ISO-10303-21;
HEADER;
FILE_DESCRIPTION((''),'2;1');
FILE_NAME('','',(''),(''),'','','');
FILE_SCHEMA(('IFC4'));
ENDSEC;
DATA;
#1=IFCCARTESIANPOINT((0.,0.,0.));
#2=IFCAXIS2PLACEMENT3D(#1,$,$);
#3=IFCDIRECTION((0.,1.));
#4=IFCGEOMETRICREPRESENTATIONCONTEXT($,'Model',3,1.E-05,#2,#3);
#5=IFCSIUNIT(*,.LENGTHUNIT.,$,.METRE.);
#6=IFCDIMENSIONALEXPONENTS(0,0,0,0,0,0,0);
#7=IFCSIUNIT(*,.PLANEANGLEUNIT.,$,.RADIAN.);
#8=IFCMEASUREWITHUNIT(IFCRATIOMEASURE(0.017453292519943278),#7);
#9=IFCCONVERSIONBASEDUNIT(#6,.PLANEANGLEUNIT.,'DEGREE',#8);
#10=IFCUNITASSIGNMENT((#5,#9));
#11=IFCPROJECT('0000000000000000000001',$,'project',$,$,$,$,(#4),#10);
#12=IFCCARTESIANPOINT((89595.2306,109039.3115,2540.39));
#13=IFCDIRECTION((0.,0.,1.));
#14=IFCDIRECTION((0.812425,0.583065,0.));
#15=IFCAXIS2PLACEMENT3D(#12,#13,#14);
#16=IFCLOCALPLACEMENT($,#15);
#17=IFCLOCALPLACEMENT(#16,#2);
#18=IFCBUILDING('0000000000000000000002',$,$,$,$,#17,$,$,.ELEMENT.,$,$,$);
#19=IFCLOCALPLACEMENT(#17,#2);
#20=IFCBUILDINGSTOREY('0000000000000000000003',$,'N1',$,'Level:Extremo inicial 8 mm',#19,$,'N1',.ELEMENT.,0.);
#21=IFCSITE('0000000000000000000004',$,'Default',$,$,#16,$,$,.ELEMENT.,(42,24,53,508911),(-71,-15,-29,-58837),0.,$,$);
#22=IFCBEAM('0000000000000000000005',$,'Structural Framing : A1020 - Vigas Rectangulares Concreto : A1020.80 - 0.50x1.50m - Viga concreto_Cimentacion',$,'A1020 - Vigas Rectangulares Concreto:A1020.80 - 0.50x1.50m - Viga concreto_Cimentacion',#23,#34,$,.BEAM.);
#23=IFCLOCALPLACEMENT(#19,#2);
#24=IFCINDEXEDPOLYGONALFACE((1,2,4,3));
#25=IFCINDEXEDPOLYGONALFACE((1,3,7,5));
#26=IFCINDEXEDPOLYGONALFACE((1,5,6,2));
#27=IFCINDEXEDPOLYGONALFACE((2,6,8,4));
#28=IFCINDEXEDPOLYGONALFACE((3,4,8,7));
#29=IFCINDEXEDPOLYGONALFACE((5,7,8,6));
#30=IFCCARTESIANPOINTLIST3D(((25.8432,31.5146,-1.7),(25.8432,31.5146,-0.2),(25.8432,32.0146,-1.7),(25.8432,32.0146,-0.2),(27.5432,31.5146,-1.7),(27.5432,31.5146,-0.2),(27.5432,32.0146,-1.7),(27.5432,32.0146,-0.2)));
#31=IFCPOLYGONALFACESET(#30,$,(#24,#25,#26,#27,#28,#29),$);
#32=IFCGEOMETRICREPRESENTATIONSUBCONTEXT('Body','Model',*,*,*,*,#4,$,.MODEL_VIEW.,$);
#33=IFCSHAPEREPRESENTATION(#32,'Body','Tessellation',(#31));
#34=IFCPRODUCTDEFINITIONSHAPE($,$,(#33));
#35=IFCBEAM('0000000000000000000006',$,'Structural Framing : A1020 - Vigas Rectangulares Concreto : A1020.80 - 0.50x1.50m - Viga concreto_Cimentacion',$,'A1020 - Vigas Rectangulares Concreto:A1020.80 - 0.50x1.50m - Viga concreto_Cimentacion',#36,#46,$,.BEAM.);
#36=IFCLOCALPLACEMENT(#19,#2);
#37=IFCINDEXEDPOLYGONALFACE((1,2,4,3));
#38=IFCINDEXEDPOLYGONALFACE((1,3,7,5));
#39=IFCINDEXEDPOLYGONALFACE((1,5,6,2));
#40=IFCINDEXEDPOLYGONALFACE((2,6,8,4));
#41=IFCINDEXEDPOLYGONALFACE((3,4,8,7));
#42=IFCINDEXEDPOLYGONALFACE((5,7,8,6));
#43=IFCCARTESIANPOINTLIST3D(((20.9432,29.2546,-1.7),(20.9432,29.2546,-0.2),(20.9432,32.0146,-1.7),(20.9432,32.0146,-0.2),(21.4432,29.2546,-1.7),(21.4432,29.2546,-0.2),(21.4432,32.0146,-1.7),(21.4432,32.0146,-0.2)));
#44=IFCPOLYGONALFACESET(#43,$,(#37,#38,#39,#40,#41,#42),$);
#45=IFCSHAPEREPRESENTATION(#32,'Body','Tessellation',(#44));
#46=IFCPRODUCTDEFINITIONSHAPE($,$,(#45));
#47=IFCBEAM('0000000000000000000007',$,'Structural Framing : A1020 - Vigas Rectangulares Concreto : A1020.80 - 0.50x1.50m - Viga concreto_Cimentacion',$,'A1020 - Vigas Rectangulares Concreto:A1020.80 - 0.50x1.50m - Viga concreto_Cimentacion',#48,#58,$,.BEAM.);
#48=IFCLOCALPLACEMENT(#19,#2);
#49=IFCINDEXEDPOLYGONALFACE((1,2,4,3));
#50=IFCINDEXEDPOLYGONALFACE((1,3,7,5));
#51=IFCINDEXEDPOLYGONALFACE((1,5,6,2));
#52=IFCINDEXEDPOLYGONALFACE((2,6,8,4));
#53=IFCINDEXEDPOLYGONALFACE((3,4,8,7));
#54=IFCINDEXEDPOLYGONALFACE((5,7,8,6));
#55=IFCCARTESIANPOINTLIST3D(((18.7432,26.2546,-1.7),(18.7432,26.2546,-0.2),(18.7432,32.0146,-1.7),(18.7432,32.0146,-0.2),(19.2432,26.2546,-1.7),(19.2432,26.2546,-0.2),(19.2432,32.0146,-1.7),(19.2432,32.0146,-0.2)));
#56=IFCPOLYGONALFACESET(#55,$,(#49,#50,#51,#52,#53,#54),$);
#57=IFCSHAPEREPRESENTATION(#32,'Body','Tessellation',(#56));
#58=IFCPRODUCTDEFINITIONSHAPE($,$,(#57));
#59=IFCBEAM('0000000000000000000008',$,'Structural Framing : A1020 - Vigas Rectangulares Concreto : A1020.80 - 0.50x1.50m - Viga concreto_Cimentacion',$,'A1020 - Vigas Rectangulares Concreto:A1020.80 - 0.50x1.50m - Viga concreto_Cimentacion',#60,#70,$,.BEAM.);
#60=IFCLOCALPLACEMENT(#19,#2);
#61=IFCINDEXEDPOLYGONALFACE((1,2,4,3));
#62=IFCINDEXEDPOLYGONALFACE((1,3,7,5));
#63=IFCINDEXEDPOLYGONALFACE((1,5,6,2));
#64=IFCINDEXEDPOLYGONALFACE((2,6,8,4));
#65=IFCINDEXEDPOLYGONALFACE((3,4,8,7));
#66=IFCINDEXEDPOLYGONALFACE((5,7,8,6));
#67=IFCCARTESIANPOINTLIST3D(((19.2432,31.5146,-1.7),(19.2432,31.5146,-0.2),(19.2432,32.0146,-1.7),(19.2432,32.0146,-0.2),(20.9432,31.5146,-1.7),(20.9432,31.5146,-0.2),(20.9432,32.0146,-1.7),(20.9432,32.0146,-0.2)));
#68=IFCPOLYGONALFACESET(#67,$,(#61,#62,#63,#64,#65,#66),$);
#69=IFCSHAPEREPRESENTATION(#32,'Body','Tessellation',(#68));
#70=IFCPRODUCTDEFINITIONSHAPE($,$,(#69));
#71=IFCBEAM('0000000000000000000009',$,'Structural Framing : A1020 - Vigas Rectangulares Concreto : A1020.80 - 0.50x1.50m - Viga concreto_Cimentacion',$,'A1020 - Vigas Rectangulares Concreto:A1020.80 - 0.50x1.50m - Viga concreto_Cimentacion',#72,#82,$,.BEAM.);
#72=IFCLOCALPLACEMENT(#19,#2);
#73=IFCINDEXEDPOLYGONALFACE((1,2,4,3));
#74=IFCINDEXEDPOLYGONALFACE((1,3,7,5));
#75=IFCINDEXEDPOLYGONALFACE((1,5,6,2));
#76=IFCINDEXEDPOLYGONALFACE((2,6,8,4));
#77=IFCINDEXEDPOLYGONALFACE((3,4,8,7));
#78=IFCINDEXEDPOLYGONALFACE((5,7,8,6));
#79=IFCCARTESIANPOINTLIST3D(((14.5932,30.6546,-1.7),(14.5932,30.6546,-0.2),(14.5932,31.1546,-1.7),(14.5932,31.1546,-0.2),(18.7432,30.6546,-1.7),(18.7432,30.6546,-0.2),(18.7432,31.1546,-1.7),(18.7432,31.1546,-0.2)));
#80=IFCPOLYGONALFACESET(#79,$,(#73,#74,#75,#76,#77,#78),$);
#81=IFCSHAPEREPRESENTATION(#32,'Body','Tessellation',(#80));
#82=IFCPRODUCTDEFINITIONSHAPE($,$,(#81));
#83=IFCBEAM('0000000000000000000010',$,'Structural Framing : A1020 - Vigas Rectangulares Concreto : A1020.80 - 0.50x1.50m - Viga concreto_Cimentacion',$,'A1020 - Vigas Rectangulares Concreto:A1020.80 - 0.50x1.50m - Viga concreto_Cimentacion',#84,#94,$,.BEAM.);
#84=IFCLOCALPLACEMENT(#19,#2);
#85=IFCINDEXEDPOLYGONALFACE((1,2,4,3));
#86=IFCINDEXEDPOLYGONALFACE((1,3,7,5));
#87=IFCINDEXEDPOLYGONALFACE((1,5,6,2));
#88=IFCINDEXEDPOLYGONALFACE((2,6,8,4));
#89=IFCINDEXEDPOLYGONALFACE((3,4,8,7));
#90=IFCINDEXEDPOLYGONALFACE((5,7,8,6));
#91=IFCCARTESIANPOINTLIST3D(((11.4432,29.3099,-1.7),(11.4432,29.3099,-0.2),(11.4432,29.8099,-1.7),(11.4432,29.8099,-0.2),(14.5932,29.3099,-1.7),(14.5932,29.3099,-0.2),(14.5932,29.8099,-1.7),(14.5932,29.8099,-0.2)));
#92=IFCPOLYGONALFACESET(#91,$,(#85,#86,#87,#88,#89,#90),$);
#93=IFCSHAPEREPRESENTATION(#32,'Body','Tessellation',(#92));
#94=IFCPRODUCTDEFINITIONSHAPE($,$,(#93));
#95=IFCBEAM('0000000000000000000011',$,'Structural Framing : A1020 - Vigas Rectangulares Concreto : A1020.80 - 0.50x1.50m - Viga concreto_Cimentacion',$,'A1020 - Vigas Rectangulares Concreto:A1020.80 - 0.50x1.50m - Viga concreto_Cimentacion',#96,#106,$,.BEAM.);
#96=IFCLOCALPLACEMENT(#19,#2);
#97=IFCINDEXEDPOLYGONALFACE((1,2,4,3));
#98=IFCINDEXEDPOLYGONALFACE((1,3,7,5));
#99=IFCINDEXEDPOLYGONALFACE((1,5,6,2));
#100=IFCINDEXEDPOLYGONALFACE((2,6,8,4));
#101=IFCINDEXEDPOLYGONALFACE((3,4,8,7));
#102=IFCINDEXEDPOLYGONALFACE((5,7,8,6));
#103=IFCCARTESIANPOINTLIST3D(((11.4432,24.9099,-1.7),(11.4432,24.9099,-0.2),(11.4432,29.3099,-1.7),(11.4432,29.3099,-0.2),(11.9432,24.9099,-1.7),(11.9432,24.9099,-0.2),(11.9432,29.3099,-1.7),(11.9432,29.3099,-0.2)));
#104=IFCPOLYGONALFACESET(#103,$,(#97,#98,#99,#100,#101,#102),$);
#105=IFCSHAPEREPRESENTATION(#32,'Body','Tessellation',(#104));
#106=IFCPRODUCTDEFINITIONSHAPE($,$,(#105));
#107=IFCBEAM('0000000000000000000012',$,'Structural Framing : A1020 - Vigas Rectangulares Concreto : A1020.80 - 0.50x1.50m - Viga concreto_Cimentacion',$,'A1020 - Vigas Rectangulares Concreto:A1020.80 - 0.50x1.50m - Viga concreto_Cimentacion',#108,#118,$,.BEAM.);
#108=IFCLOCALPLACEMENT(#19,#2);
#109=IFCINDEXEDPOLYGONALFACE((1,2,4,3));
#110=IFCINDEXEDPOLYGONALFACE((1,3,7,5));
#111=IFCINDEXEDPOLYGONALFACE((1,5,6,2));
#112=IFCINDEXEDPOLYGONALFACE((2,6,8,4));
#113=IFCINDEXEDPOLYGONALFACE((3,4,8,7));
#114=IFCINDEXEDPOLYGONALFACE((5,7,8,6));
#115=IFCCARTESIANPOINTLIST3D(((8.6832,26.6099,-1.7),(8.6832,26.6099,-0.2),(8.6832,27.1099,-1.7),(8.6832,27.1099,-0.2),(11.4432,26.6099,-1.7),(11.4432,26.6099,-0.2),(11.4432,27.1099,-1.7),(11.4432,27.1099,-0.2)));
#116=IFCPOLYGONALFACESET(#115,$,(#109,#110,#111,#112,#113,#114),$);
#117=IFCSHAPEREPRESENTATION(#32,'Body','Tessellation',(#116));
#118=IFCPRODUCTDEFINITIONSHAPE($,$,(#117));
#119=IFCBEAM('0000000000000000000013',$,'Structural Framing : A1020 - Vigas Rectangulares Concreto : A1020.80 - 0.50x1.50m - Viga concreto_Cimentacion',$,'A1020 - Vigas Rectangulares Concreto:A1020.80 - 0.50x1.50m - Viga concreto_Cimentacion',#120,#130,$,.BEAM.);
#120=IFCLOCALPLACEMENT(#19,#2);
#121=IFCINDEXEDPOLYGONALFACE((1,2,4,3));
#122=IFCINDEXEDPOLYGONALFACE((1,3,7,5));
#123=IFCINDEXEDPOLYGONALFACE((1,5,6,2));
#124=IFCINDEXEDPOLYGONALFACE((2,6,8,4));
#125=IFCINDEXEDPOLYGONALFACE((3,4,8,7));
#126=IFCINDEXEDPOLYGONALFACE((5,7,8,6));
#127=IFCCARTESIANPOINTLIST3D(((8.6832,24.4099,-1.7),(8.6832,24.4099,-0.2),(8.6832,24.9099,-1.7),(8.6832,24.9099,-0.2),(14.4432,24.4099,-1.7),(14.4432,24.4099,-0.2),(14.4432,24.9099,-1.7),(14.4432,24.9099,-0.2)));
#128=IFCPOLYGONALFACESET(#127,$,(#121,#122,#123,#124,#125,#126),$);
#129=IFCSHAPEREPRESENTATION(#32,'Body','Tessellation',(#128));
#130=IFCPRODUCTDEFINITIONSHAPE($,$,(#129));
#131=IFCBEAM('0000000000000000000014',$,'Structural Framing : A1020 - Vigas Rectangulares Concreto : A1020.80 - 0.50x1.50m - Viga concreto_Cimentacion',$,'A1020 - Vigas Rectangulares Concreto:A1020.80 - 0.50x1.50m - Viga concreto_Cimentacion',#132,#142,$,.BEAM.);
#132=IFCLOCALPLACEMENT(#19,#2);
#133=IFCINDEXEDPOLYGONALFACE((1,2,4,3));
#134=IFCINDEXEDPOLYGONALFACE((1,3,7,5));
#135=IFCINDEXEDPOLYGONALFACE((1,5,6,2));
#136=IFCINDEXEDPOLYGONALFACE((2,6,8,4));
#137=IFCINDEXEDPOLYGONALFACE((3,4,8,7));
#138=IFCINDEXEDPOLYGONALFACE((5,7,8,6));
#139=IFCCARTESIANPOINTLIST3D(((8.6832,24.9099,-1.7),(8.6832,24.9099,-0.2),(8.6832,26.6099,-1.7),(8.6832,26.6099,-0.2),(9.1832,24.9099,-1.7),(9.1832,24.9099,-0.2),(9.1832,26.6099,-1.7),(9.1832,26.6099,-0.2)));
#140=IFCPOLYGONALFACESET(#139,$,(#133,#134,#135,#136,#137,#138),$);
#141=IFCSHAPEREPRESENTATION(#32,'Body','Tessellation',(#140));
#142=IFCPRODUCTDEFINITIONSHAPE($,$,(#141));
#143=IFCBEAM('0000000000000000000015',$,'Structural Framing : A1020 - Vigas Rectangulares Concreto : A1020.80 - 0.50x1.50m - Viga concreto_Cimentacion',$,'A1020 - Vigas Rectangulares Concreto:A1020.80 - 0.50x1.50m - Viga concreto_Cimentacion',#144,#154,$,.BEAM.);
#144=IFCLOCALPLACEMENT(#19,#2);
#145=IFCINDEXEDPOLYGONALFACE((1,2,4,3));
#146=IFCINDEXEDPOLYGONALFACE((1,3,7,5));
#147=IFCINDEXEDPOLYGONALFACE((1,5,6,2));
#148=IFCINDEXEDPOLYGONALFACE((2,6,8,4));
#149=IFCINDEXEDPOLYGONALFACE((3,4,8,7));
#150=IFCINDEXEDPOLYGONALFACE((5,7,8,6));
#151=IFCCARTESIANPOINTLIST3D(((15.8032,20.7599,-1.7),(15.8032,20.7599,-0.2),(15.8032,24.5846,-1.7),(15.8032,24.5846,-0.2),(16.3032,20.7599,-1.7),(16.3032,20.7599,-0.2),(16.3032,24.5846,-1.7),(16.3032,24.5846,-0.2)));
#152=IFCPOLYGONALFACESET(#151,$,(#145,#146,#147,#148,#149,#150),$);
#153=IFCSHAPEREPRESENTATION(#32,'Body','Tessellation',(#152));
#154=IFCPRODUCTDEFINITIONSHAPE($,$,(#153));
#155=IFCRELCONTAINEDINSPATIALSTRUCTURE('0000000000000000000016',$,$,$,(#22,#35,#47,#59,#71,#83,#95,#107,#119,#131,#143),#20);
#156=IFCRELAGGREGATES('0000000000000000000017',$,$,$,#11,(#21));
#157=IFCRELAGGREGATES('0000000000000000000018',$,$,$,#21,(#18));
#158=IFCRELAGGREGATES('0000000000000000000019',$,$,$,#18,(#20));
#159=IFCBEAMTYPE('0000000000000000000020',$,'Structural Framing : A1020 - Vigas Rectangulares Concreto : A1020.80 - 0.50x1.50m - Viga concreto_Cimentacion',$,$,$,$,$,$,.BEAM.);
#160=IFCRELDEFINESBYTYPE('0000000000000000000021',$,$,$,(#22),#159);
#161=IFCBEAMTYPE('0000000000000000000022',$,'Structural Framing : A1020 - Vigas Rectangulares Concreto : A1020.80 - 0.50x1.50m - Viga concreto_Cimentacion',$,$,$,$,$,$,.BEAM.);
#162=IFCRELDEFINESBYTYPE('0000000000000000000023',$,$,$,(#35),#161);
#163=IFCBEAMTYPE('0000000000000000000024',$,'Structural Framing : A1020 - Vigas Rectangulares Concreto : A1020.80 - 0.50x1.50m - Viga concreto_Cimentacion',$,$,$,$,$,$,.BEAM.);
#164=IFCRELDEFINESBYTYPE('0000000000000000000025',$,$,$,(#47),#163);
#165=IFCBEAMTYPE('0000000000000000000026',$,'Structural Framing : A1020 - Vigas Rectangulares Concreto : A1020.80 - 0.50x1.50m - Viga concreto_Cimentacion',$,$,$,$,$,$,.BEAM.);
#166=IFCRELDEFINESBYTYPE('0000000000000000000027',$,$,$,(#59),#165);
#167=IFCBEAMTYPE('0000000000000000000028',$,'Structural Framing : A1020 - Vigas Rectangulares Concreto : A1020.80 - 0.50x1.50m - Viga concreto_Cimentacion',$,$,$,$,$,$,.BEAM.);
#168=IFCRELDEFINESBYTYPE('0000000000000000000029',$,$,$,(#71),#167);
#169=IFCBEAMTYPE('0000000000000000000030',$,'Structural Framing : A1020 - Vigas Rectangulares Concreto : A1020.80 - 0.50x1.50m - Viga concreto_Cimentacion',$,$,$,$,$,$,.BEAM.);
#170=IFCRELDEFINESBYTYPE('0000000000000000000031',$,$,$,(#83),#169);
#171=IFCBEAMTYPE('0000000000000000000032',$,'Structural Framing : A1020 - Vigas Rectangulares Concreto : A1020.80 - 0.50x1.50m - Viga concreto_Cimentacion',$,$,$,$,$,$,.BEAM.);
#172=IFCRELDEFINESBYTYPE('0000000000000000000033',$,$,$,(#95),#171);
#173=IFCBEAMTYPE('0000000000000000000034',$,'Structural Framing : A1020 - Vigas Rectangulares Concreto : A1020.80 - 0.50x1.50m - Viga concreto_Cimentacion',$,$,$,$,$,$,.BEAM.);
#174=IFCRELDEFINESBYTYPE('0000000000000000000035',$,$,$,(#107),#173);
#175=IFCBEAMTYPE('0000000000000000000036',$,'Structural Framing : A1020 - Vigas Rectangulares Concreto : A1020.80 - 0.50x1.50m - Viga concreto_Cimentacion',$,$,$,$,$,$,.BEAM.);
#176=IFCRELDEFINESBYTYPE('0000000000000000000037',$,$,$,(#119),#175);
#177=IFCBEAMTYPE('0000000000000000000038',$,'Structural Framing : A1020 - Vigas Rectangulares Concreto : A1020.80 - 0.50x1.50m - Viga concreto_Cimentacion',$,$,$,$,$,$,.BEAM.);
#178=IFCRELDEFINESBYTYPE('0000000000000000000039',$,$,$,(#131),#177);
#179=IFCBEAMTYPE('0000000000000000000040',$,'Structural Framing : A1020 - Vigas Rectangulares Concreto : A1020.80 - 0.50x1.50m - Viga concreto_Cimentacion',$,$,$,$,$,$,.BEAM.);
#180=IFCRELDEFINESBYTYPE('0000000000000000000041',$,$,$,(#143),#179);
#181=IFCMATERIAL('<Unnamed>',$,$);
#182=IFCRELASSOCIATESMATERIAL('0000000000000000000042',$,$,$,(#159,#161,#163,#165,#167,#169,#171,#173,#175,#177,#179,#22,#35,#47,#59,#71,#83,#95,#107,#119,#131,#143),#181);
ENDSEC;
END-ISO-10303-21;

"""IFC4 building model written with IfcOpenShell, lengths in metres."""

from ifc_helpers import new_model, entity, si_unit, converted_unit, direction, frame, frame_2d, origin, origin_2d_with_axis, place, context, subcontext, project, spatial, polyline, segment, composite_curve, rectangle, outline, extrude, source, transform, mapped, material, material_profile, profile_set, profile_usage, type_object, type_shapes, element, save


model = new_model("IFC4")

# Units and contexts
model_context = context("Model", 3, precision=1e-05, world=origin(), true_north=direction((0.0, 1.0)))
body_context = subcontext(model_context, "Body", "Model", "MODEL_VIEW")
ifc_project = project(units=[si_unit("LENGTHUNIT", "METRE"), converted_unit("PLANEANGLEUNIT", "DEGREE", entity("IfcRatioMeasure", 0.017453292519943278), si_unit("PLANEANGLEUNIT", "RADIAN"), dimensions=[0, 0, 0, 0, 0, 0, 0])], contexts=[model_context])

# Site, building, storey
site_placement = place(None, frame((89595.2306, 109039.3115, 2540.39), z_axis=(0.0, 0.0, 1.0), x_axis=(0.812425, 0.583065, 0.0)))
site = spatial("IfcSite", under=ifc_project, at=site_placement, Name="Default", CompositionType="ELEMENT", RefLatitude=(42, 24, 53, 508911), RefLongitude=(-71, -15, -29, -58837), RefElevation=0.0)
building_placement = place(site_placement, origin())
building = spatial("IfcBuilding", under=site, at=building_placement, CompositionType="ELEMENT")
storey_placement = place(building_placement, origin())
storey = spatial("IfcBuildingStorey", under=building, at=storey_placement, Name="N1", ObjectType="Level:Extremo inicial 8 mm", LongName="N1", CompositionType="ELEMENT", Elevation=0.0)

# Beams
ifc_material = material(Name="<Unnamed>")
ifc_material_profile_1 = material_profile(ifc_material, outline(composite_curve([segment(polyline([(0.25, 0.75, 0.0), (0.25, -0.75, 0.0)]), True, "CONTINUOUS"), segment(polyline([(0.25, -0.75, 0.0), (-0.25, -0.75, 0.0)]), True, "CONTINUOUS"), segment(polyline([(-0.25, -0.75, 0.0), (-0.25, 0.75, 0.0)]), True, "CONTINUOUS"), segment(polyline([(-0.25, 0.75, 0.0), (0.25, 0.75, 0.0)]), True, "CONTINUOUS")], self_intersect=False), kind="CURVE"), Name="A1020.80 - 0.50x1.50m - Viga concreto_Cimentacion")
ifc_material_profile_2 = material_profile(ifc_material, outline(composite_curve([segment(polyline([(-5.3373, 0.25, 0.75), (-5.3373, 0.25, -0.75)]), True, "CONTINUOUS"), segment(polyline([(-5.3373, 0.25, -0.75), (-5.3373, -0.25, -0.75)]), True, "CONTINUOUS"), segment(polyline([(-5.3373, -0.25, -0.75), (-5.3373, -0.25, 0.75)]), True, "CONTINUOUS"), segment(polyline([(-5.3373, -0.25, 0.75), (-5.3373, 0.25, 0.75)]), True, "CONTINUOUS")], self_intersect=False), kind="CURVE"), Name="A1020.80 - 0.50x1.50m - Viga concreto_Cimentacion")
ifc_profile_set_1 = profile_set([ifc_material_profile_1, ifc_material_profile_2], Name="A1020.80 - 0.50x1.50m - Viga concreto_Cimentacion")
ifc_profile_usage_1 = profile_usage(ifc_profile_set_1, cardinal=8)
beam_type_1 = type_object("IfcBeamType", Name="Structural Framing : A1020 - Vigas Rectangulares Concreto : A1020.80 - 0.50x1.50m - Viga concreto_Cimentacion", PredefinedType="BEAM", material=ifc_profile_set_1)
shared_shape_1 = source(origin(), body_context, "Body", "SweptSolid", [
    extrude(rectangle(XDim=1.5, YDim=0.5, at=frame_2d((0.0, 0.0), x_axis=(1.0, 0.0))), frame((27.5432, 31.7646, -0.95), z_axis=(-1.0, 0.0, 0.0), x_axis=(0.0, 0.0, -1.0)), (0.0, 0.0, 1.0), 1.7),
])
type_shapes(beam_type_1, [shared_shape_1])
beam_1_placement = place(storey_placement, origin())
element("IfcBeam", 1, at=beam_1_placement, inside=storey, type_object=beam_type_1, material=ifc_profile_usage_1, Name="Structural Framing : A1020 - Vigas Rectangulares Concreto : A1020.80 - 0.50x1.50m - Viga concreto_Cimentacion", ObjectType="A1020 - Vigas Rectangulares Concreto:A1020.80 - 0.50x1.50m - Viga concreto_Cimentacion", PredefinedType="BEAM", context=body_context, shape_type="MappedRepresentation", body=[
    mapped(shared_shape_1, transform((0.0, 0.0, 0.0), scale=1.0)),
])
ifc_profile_usage_2 = profile_usage(ifc_profile_set_1, cardinal=8)
beam_type_2 = type_object("IfcBeamType", Name="Structural Framing : A1020 - Vigas Rectangulares Concreto : A1020.80 - 0.50x1.50m - Viga concreto_Cimentacion", PredefinedType="BEAM", material=ifc_profile_set_1)
shared_shape_2 = source(origin(), body_context, "Body", "SweptSolid", [
    extrude(rectangle(XDim=1.5, YDim=0.5, at=frame_2d((0.0, 0.0), x_axis=(0.0, 1.0))), frame((21.1932, 29.2546, -0.95), z_axis=(0.0, 1.0, 0.0), x_axis=(-1.0, 0.0, 0.0)), (0.0, 0.0, 1.0), 2.76),
])
type_shapes(beam_type_2, [shared_shape_2])
beam_2_placement = place(storey_placement, origin())
element("IfcBeam", 2, at=beam_2_placement, inside=storey, type_object=beam_type_2, material=ifc_profile_usage_2, Name="Structural Framing : A1020 - Vigas Rectangulares Concreto : A1020.80 - 0.50x1.50m - Viga concreto_Cimentacion", ObjectType="A1020 - Vigas Rectangulares Concreto:A1020.80 - 0.50x1.50m - Viga concreto_Cimentacion", PredefinedType="BEAM", context=body_context, shape_type="MappedRepresentation", body=[
    mapped(shared_shape_2, transform((0.0, 0.0, 0.0), scale=1.0)),
])
ifc_profile_usage_3 = profile_usage(ifc_profile_set_1, cardinal=8)
beam_type_3 = type_object("IfcBeamType", Name="Structural Framing : A1020 - Vigas Rectangulares Concreto : A1020.80 - 0.50x1.50m - Viga concreto_Cimentacion", PredefinedType="BEAM", material=ifc_profile_set_1)
shared_shape_3 = source(origin(), body_context, "Body", "SweptSolid", [
    extrude(rectangle(XDim=1.5, YDim=0.5, at=frame_2d((0.0, 0.0), x_axis=(0.0, 1.0))), frame((18.9932, 26.2546, -0.95), z_axis=(0.0, 1.0, 0.0), x_axis=(-1.0, 0.0, 0.0)), (0.0, 0.0, 1.0), 5.76),
])
type_shapes(beam_type_3, [shared_shape_3])
beam_3_placement = place(storey_placement, origin())
element("IfcBeam", 3, at=beam_3_placement, inside=storey, type_object=beam_type_3, material=ifc_profile_usage_3, Name="Structural Framing : A1020 - Vigas Rectangulares Concreto : A1020.80 - 0.50x1.50m - Viga concreto_Cimentacion", ObjectType="A1020 - Vigas Rectangulares Concreto:A1020.80 - 0.50x1.50m - Viga concreto_Cimentacion", PredefinedType="BEAM", context=body_context, shape_type="MappedRepresentation", body=[
    mapped(shared_shape_3, transform((0.0, 0.0, 0.0), scale=1.0)),
])
ifc_profile_usage_4 = profile_usage(ifc_profile_set_1, cardinal=8)
beam_type_4 = type_object("IfcBeamType", Name="Structural Framing : A1020 - Vigas Rectangulares Concreto : A1020.80 - 0.50x1.50m - Viga concreto_Cimentacion", PredefinedType="BEAM", material=ifc_profile_set_1)
shared_shape_4 = source(origin(), body_context, "Body", "SweptSolid", [
    extrude(rectangle(XDim=1.5, YDim=0.5, at=origin_2d_with_axis()), frame((19.2432, 31.7646, -0.95), z_axis=(1.0, 0.0, 0.0), x_axis=(0.0, 0.0, -1.0)), (0.0, 0.0, 1.0), 1.7),
])
type_shapes(beam_type_4, [shared_shape_4])
beam_4_placement = place(storey_placement, origin())
element("IfcBeam", 4, at=beam_4_placement, inside=storey, type_object=beam_type_4, material=ifc_profile_usage_4, Name="Structural Framing : A1020 - Vigas Rectangulares Concreto : A1020.80 - 0.50x1.50m - Viga concreto_Cimentacion", ObjectType="A1020 - Vigas Rectangulares Concreto:A1020.80 - 0.50x1.50m - Viga concreto_Cimentacion", PredefinedType="BEAM", context=body_context, shape_type="MappedRepresentation", body=[
    mapped(shared_shape_4, transform((0.0, 0.0, 0.0), scale=1.0)),
])
ifc_profile_usage_5 = profile_usage(ifc_profile_set_1, cardinal=8)
beam_type_5 = type_object("IfcBeamType", Name="Structural Framing : A1020 - Vigas Rectangulares Concreto : A1020.80 - 0.50x1.50m - Viga concreto_Cimentacion", PredefinedType="BEAM", material=ifc_profile_set_1)
shared_shape_5 = source(origin(), body_context, "Body", "SweptSolid", [
    extrude(rectangle(XDim=1.5, YDim=0.5, at=frame_2d((0.0, 0.0), x_axis=(1.0, 0.0))), frame((18.7432, 30.9046, -0.95), z_axis=(-1.0, 0.0, 0.0), x_axis=(0.0, 0.0, -1.0)), (0.0, 0.0, 1.0), 4.15),
])
type_shapes(beam_type_5, [shared_shape_5])
beam_5_placement = place(storey_placement, origin())
element("IfcBeam", 5, at=beam_5_placement, inside=storey, type_object=beam_type_5, material=ifc_profile_usage_5, Name="Structural Framing : A1020 - Vigas Rectangulares Concreto : A1020.80 - 0.50x1.50m - Viga concreto_Cimentacion", ObjectType="A1020 - Vigas Rectangulares Concreto:A1020.80 - 0.50x1.50m - Viga concreto_Cimentacion", PredefinedType="BEAM", context=body_context, shape_type="MappedRepresentation", body=[
    mapped(shared_shape_5, transform((0.0, 0.0, 0.0), scale=1.0)),
])
ifc_profile_usage_6 = profile_usage(ifc_profile_set_1, cardinal=8)
beam_type_6 = type_object("IfcBeamType", Name="Structural Framing : A1020 - Vigas Rectangulares Concreto : A1020.80 - 0.50x1.50m - Viga concreto_Cimentacion", PredefinedType="BEAM", material=ifc_profile_set_1)
shared_shape_6 = source(origin(), body_context, "Body", "SweptSolid", [
    extrude(rectangle(XDim=1.5, YDim=0.5, at=frame_2d((0.0, 0.0), x_axis=(1.0, 0.0))), frame((11.4432, 29.5599, -0.95), z_axis=(1.0, 0.0, 0.0), x_axis=(0.0, 0.0, -1.0)), (0.0, 0.0, 1.0), 3.15),
])
type_shapes(beam_type_6, [shared_shape_6])
beam_6_placement = place(storey_placement, origin())
element("IfcBeam", 6, at=beam_6_placement, inside=storey, type_object=beam_type_6, material=ifc_profile_usage_6, Name="Structural Framing : A1020 - Vigas Rectangulares Concreto : A1020.80 - 0.50x1.50m - Viga concreto_Cimentacion", ObjectType="A1020 - Vigas Rectangulares Concreto:A1020.80 - 0.50x1.50m - Viga concreto_Cimentacion", PredefinedType="BEAM", context=body_context, shape_type="MappedRepresentation", body=[
    mapped(shared_shape_6, transform((0.0, 0.0, 0.0), scale=1.0)),
])
ifc_profile_usage_7 = profile_usage(ifc_profile_set_1, cardinal=8)
beam_type_7 = type_object("IfcBeamType", Name="Structural Framing : A1020 - Vigas Rectangulares Concreto : A1020.80 - 0.50x1.50m - Viga concreto_Cimentacion", PredefinedType="BEAM", material=ifc_profile_set_1)
shared_shape_7 = source(origin(), body_context, "Body", "SweptSolid", [
    extrude(rectangle(XDim=1.5, YDim=0.5, at=frame_2d((0.0, 0.0), x_axis=(0.0, 1.0))), frame((11.6932, 29.3099, -0.95), z_axis=(0.0, -1.0, 0.0), x_axis=(-1.0, 0.0, 0.0)), (0.0, 0.0, 1.0), 4.4),
])
type_shapes(beam_type_7, [shared_shape_7])
beam_7_placement = place(storey_placement, origin())
element("IfcBeam", 7, at=beam_7_placement, inside=storey, type_object=beam_type_7, material=ifc_profile_usage_7, Name="Structural Framing : A1020 - Vigas Rectangulares Concreto : A1020.80 - 0.50x1.50m - Viga concreto_Cimentacion", ObjectType="A1020 - Vigas Rectangulares Concreto:A1020.80 - 0.50x1.50m - Viga concreto_Cimentacion", PredefinedType="BEAM", context=body_context, shape_type="MappedRepresentation", body=[
    mapped(shared_shape_7, transform((0.0, 0.0, 0.0), scale=1.0)),
])
ifc_profile_usage_8 = profile_usage(ifc_profile_set_1, cardinal=8)
beam_type_8 = type_object("IfcBeamType", Name="Structural Framing : A1020 - Vigas Rectangulares Concreto : A1020.80 - 0.50x1.50m - Viga concreto_Cimentacion", PredefinedType="BEAM", material=ifc_profile_set_1)
shared_shape_8 = source(origin(), body_context, "Body", "SweptSolid", [
    extrude(rectangle(XDim=1.5, YDim=0.5, at=frame_2d((0.0, 0.0), x_axis=(1.0, 0.0))), frame((11.4432, 26.8599, -0.95), z_axis=(-1.0, 0.0, 0.0), x_axis=(0.0, 0.0, -1.0)), (0.0, 0.0, 1.0), 2.76),
])
type_shapes(beam_type_8, [shared_shape_8])
beam_8_placement = place(storey_placement, origin())
element("IfcBeam", 8, at=beam_8_placement, inside=storey, type_object=beam_type_8, material=ifc_profile_usage_8, Name="Structural Framing : A1020 - Vigas Rectangulares Concreto : A1020.80 - 0.50x1.50m - Viga concreto_Cimentacion", ObjectType="A1020 - Vigas Rectangulares Concreto:A1020.80 - 0.50x1.50m - Viga concreto_Cimentacion", PredefinedType="BEAM", context=body_context, shape_type="MappedRepresentation", body=[
    mapped(shared_shape_8, transform((0.0, 0.0, 0.0), scale=1.0)),
])
ifc_profile_usage_9 = profile_usage(ifc_profile_set_1, cardinal=8)
beam_type_9 = type_object("IfcBeamType", Name="Structural Framing : A1020 - Vigas Rectangulares Concreto : A1020.80 - 0.50x1.50m - Viga concreto_Cimentacion", PredefinedType="BEAM", material=ifc_profile_set_1)
shared_shape_9 = source(origin(), body_context, "Body", "SweptSolid", [
    extrude(rectangle(XDim=1.5, YDim=0.5, at=frame_2d((0.0, 0.0), x_axis=(1.0, 0.0))), frame((14.4432, 24.6599, -0.95), z_axis=(-1.0, 0.0, 0.0), x_axis=(0.0, 0.0, -1.0)), (0.0, 0.0, 1.0), 5.76),
])
type_shapes(beam_type_9, [shared_shape_9])
beam_9_placement = place(storey_placement, origin())
element("IfcBeam", 9, at=beam_9_placement, inside=storey, type_object=beam_type_9, material=ifc_profile_usage_9, Name="Structural Framing : A1020 - Vigas Rectangulares Concreto : A1020.80 - 0.50x1.50m - Viga concreto_Cimentacion", ObjectType="A1020 - Vigas Rectangulares Concreto:A1020.80 - 0.50x1.50m - Viga concreto_Cimentacion", PredefinedType="BEAM", context=body_context, shape_type="MappedRepresentation", body=[
    mapped(shared_shape_9, transform((0.0, 0.0, 0.0), scale=1.0)),
])
ifc_profile_usage_10 = profile_usage(ifc_profile_set_1, cardinal=8)
beam_type_10 = type_object("IfcBeamType", Name="Structural Framing : A1020 - Vigas Rectangulares Concreto : A1020.80 - 0.50x1.50m - Viga concreto_Cimentacion", PredefinedType="BEAM", material=ifc_profile_set_1)
shared_shape_10 = source(origin(), body_context, "Body", "SweptSolid", [
    extrude(rectangle(XDim=1.5, YDim=0.5, at=frame_2d((0.0, 0.0), x_axis=(0.0, 1.0))), frame((8.9332, 26.6099, -0.95), z_axis=(0.0, -1.0, 0.0), x_axis=(-1.0, 0.0, 0.0)), (0.0, 0.0, 1.0), 1.7),
])
type_shapes(beam_type_10, [shared_shape_10])
beam_10_placement = place(storey_placement, origin())
element("IfcBeam", 10, at=beam_10_placement, inside=storey, type_object=beam_type_10, material=ifc_profile_usage_10, Name="Structural Framing : A1020 - Vigas Rectangulares Concreto : A1020.80 - 0.50x1.50m - Viga concreto_Cimentacion", ObjectType="A1020 - Vigas Rectangulares Concreto:A1020.80 - 0.50x1.50m - Viga concreto_Cimentacion", PredefinedType="BEAM", context=body_context, shape_type="MappedRepresentation", body=[
    mapped(shared_shape_10, transform((0.0, 0.0, 0.0), scale=1.0)),
])
ifc_profile_usage_11 = profile_usage(ifc_profile_set_1, cardinal=8)
beam_type_11 = type_object("IfcBeamType", Name="Structural Framing : A1020 - Vigas Rectangulares Concreto : A1020.80 - 0.50x1.50m - Viga concreto_Cimentacion", PredefinedType="BEAM", material=ifc_profile_set_1)
shared_shape_11 = source(origin(), body_context, "Body", "SweptSolid", [
    extrude(rectangle(XDim=1.5, YDim=0.5, at=frame_2d((0.0, 0.0), x_axis=(0.0, 1.0))), frame((16.0532, 20.7599, -0.95), z_axis=(0.0, 1.0, 0.0), x_axis=(-1.0, 0.0, 0.0)), (0.0, 0.0, 1.0), 3.8247),
])
type_shapes(beam_type_11, [shared_shape_11])
beam_11_placement = place(storey_placement, origin())
element("IfcBeam", 11, at=beam_11_placement, inside=storey, type_object=beam_type_11, material=ifc_profile_usage_11, Name="Structural Framing : A1020 - Vigas Rectangulares Concreto : A1020.80 - 0.50x1.50m - Viga concreto_Cimentacion", ObjectType="A1020 - Vigas Rectangulares Concreto:A1020.80 - 0.50x1.50m - Viga concreto_Cimentacion", PredefinedType="BEAM", context=body_context, shape_type="MappedRepresentation", body=[
    mapped(shared_shape_11, transform((0.0, 0.0, 0.0), scale=1.0)),
])

save(model, "model.ifc")
